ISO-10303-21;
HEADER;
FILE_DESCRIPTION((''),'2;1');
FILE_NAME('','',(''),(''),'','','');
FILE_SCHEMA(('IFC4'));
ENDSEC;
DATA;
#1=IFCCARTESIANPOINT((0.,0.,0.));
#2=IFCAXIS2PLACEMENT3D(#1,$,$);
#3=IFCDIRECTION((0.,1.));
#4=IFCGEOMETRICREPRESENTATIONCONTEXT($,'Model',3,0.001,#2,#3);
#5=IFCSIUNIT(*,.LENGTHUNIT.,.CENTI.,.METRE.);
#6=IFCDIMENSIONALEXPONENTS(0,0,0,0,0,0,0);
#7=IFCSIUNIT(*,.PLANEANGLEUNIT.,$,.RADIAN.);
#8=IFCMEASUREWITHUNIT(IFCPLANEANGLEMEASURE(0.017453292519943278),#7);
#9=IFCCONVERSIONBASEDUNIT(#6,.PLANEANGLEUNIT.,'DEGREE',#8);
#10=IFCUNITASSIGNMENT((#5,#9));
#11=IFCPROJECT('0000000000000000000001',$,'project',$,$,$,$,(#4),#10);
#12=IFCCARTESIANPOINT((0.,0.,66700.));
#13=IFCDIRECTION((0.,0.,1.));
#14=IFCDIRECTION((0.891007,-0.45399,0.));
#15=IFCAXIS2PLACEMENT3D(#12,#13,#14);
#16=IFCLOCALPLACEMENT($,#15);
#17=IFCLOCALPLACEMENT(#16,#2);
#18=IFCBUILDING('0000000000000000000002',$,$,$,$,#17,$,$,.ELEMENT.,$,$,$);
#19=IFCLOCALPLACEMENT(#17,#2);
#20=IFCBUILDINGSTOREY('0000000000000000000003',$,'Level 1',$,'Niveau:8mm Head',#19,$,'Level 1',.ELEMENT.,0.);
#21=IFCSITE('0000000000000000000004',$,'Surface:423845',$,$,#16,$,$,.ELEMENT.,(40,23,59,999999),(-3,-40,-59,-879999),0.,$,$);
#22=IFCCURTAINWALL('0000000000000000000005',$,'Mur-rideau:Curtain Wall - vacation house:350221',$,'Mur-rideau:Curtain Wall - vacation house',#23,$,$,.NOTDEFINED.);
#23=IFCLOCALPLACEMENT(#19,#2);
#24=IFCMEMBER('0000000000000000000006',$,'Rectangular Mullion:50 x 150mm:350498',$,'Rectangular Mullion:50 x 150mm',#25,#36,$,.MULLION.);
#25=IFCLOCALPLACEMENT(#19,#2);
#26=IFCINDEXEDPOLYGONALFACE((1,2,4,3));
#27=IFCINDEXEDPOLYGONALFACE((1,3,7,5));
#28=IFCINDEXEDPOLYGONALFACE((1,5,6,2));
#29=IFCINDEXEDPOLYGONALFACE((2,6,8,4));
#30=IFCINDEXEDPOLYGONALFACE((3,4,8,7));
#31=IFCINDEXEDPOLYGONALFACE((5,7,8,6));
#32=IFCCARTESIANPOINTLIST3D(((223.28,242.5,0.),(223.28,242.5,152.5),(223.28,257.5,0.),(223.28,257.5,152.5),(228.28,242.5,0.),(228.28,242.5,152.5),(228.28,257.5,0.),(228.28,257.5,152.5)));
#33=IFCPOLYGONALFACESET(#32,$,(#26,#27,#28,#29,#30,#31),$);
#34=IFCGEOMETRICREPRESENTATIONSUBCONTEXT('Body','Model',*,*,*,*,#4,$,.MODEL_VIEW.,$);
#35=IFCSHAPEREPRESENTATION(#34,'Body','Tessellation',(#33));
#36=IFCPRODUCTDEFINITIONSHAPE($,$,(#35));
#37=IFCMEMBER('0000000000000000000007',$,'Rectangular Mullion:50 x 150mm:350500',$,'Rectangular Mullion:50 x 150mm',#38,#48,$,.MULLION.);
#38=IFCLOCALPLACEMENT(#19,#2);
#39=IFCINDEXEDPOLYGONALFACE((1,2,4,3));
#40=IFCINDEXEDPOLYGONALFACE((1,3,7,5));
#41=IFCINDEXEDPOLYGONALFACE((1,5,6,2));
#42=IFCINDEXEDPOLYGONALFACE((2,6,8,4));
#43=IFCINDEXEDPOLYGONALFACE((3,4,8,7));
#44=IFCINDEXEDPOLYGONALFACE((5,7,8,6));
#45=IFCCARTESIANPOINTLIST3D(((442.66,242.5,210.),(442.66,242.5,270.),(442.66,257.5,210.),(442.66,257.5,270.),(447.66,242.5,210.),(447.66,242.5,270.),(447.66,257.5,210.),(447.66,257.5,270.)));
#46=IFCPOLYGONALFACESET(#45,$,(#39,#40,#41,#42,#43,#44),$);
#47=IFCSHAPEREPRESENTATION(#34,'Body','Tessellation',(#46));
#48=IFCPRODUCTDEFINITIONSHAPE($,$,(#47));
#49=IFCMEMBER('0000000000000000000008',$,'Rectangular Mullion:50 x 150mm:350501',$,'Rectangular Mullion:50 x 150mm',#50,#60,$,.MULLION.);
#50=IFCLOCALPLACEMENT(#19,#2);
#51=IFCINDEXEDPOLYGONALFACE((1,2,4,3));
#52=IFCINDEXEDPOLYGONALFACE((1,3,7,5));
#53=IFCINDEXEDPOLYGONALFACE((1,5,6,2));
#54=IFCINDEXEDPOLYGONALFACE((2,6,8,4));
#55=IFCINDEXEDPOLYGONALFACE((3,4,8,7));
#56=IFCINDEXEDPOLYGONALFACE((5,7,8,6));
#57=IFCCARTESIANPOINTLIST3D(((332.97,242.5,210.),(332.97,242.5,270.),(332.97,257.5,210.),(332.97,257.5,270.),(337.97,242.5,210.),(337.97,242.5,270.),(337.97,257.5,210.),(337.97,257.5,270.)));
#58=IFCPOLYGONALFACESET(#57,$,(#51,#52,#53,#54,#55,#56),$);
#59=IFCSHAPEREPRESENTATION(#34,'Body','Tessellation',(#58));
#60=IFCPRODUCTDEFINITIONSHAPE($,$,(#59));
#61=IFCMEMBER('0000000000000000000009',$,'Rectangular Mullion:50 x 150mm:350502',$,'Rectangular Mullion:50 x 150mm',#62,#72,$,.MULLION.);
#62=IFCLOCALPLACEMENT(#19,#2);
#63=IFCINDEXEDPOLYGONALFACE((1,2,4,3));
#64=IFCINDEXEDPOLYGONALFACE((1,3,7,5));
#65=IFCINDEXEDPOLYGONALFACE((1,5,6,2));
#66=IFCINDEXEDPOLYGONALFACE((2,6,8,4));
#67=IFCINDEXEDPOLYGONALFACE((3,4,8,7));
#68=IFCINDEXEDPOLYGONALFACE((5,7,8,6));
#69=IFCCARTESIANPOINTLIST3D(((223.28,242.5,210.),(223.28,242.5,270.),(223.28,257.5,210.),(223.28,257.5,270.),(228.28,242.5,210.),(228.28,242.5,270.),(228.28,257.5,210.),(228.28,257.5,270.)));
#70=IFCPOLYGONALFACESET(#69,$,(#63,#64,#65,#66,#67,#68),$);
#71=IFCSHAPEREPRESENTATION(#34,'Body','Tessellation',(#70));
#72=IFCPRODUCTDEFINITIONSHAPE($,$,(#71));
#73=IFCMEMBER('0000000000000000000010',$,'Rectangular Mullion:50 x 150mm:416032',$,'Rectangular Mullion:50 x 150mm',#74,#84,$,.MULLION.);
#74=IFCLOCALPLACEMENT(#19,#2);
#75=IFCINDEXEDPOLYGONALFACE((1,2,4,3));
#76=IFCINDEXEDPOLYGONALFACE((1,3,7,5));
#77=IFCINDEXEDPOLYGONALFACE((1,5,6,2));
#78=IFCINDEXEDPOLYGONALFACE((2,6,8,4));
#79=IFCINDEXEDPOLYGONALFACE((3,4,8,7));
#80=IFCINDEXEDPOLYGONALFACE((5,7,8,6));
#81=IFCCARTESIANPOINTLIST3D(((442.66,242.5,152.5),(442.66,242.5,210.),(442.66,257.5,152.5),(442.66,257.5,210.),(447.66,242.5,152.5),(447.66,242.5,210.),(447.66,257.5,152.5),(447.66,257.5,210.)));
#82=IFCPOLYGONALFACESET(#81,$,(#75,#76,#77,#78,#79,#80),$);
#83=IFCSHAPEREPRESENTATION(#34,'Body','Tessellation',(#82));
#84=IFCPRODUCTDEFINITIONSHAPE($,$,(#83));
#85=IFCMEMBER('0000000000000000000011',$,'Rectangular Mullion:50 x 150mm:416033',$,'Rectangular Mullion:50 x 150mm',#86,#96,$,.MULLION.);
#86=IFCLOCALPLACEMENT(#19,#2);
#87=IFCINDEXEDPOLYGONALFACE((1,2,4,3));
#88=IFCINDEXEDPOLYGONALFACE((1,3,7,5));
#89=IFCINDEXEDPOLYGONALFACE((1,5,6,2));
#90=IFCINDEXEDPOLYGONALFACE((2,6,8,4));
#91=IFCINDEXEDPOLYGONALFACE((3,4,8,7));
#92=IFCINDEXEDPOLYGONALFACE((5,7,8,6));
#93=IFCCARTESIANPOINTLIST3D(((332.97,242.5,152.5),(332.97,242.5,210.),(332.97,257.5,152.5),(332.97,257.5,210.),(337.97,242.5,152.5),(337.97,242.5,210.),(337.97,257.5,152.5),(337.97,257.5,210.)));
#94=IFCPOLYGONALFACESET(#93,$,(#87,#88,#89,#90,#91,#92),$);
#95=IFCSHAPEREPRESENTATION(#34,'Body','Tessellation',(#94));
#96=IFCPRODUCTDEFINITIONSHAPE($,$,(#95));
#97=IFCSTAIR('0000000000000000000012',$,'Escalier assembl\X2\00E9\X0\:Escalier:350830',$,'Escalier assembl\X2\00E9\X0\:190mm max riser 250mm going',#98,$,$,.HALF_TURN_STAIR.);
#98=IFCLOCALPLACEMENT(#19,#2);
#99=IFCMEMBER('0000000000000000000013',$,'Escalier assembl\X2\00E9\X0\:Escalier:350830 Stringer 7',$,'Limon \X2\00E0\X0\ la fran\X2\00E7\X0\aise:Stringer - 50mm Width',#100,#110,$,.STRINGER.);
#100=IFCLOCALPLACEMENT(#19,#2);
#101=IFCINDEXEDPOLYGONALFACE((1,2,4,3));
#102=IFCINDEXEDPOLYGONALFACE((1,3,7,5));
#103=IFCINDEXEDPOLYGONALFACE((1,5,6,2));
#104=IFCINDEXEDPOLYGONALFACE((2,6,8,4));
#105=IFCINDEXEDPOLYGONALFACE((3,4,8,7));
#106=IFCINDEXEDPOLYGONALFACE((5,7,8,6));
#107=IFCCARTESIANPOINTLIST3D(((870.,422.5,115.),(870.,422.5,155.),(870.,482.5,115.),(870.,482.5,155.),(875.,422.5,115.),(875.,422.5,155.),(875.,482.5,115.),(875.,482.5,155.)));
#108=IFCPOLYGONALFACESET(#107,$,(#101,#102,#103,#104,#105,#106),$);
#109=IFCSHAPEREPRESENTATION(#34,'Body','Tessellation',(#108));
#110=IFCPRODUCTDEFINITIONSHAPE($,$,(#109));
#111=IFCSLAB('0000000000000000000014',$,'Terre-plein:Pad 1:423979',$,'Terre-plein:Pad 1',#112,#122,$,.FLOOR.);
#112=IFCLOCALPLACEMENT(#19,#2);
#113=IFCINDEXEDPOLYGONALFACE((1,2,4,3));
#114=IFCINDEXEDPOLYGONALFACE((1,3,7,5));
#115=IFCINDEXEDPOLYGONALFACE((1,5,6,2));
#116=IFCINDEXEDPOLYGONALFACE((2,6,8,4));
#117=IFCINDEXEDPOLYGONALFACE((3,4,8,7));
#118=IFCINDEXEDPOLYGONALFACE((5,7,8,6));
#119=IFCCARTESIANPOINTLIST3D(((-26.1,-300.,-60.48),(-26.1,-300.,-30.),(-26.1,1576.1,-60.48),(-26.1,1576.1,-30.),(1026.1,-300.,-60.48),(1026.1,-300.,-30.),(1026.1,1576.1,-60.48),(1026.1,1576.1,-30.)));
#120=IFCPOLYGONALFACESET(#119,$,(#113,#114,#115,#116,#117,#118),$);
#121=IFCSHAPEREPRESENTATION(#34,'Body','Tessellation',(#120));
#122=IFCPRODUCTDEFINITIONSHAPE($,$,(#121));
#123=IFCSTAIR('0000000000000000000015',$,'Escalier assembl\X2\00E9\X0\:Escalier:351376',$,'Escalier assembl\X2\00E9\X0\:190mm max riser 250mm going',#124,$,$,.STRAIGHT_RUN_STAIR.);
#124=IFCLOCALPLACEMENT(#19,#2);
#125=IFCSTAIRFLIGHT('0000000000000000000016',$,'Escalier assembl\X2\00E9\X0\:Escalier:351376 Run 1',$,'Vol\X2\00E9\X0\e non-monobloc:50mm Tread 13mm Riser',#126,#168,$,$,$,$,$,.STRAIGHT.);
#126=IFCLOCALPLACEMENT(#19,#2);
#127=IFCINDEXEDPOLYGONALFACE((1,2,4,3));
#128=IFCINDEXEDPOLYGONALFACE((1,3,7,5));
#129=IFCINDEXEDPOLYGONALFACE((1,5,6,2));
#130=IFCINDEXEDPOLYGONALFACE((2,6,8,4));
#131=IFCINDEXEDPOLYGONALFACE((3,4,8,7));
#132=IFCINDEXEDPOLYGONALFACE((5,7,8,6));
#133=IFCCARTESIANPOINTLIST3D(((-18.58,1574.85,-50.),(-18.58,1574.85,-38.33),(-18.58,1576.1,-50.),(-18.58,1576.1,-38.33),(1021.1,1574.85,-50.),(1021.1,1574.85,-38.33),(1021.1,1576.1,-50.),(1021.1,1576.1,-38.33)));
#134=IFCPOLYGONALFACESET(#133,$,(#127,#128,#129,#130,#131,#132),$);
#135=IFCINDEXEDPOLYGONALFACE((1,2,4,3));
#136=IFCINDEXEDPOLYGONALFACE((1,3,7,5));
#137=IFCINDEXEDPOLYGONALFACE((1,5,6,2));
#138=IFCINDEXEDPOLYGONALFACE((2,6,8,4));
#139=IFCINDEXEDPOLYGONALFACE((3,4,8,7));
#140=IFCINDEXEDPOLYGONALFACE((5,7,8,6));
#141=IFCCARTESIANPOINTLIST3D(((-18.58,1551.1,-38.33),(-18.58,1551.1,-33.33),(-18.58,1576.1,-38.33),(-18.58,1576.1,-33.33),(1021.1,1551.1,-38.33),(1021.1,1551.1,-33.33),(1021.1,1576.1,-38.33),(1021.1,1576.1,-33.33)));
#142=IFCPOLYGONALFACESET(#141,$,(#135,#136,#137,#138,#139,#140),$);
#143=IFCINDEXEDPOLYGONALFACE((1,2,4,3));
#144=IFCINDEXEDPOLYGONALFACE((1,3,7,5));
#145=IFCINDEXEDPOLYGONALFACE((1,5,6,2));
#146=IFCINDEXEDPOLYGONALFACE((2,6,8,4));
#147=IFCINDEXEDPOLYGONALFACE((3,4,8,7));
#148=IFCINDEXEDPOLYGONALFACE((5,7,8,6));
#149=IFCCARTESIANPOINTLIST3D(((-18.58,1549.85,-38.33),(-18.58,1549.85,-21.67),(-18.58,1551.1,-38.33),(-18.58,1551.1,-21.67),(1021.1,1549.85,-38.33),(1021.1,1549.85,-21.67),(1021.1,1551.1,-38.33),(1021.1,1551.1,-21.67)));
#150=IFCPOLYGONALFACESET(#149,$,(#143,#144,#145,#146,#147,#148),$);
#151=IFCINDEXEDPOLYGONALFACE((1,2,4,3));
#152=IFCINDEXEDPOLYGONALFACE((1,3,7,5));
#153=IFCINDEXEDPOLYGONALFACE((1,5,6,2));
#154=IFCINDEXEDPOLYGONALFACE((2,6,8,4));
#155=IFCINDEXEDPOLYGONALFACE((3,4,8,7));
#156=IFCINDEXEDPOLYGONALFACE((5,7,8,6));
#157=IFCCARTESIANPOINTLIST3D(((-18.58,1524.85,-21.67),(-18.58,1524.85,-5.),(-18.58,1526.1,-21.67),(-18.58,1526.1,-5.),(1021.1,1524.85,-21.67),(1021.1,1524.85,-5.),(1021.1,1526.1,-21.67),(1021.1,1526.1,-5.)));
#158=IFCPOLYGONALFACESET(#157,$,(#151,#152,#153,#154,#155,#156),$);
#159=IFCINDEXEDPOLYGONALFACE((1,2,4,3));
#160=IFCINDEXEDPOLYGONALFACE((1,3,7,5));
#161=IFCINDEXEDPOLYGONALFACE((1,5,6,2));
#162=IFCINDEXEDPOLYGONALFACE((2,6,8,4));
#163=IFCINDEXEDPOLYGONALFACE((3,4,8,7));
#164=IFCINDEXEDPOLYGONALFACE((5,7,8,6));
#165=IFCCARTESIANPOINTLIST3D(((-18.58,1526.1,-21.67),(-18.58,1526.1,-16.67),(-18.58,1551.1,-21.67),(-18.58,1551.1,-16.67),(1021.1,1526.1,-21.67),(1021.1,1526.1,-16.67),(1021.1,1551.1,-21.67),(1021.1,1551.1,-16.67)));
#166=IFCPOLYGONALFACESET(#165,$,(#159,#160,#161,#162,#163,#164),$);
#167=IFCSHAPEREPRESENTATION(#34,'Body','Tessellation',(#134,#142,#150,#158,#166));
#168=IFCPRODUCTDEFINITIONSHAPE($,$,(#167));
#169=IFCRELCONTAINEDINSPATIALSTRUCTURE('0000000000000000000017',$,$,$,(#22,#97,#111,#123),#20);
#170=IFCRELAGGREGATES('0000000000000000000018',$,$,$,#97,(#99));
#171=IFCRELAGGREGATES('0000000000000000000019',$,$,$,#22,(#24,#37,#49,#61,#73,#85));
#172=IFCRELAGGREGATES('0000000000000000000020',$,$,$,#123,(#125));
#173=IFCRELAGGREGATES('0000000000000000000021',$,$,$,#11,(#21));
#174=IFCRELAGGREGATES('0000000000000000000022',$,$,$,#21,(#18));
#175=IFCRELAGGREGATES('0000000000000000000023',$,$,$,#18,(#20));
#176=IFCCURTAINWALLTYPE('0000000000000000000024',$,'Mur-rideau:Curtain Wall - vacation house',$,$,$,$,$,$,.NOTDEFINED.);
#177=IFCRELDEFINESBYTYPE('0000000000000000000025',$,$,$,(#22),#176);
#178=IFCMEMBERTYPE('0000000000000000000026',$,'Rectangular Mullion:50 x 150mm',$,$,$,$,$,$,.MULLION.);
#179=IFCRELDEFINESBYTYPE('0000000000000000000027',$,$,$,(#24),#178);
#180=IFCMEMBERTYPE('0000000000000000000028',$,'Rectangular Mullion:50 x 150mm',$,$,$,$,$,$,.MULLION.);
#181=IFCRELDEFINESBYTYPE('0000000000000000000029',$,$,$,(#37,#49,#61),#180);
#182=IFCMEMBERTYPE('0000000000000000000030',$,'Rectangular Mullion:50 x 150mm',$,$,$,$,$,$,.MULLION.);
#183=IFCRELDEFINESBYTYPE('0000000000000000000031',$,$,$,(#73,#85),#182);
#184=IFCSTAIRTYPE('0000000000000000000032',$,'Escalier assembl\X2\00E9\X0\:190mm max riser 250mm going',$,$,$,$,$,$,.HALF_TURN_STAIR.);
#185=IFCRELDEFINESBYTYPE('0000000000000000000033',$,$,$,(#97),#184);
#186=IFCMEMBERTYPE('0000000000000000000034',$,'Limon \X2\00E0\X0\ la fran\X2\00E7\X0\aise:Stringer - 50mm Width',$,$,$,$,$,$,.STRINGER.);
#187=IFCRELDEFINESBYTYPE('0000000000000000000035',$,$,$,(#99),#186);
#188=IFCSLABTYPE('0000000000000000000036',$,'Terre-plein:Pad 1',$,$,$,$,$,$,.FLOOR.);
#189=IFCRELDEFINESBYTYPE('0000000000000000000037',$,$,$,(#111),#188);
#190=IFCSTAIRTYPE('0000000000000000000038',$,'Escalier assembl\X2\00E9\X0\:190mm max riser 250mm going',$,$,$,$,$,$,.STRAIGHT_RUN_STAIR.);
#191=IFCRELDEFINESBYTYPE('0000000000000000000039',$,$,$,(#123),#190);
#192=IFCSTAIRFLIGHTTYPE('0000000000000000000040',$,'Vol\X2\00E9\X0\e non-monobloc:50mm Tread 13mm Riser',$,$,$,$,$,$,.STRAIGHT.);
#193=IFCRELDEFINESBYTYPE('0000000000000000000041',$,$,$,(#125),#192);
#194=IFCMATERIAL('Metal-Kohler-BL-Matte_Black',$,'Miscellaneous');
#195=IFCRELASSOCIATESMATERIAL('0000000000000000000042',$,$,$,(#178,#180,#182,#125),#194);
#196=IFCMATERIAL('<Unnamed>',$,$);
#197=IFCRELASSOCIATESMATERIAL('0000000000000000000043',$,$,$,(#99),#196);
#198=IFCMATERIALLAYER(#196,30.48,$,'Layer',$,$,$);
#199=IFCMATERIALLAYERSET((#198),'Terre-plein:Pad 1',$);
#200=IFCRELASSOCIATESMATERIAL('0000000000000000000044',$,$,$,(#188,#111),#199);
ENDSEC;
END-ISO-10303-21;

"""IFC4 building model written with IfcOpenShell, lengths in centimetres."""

from ifc_helpers import new_model, entity, si_unit, converted_unit, direction, frame, frame_2d, origin, origin_2d_with_axis, place, context, subcontext, project, spatial, rectangle, extrude, source, transform, mapped, material, layer, layer_set, layer_usage, material_profile, profile_set, type_object, type_shapes, element, aggregate, save


model = new_model("IFC4")

# Units and contexts
model_context = context("Model", 3, precision=0.001, world=origin(), true_north=direction((0.0, 1.0)))
body_context = subcontext(model_context, "Body", "Model", "MODEL_VIEW")
ifc_project = project(units=[si_unit("LENGTHUNIT", "METRE", prefix="CENTI"), converted_unit("PLANEANGLEUNIT", "DEGREE", entity("IfcPlaneAngleMeasure", 0.017453292519943278), si_unit("PLANEANGLEUNIT", "RADIAN"), dimensions=[0, 0, 0, 0, 0, 0, 0])], contexts=[model_context])

# Site, building, storey
site_placement = place(None, frame((0.0, 0.0, 66700.0), z_axis=(0.0, 0.0, 1.0), x_axis=(0.891007, -0.45399, 0.0)))
site = spatial("IfcSite", under=ifc_project, at=site_placement, Name="Surface:423845", CompositionType="ELEMENT", RefLatitude=(40, 23, 59, 999999), RefLongitude=(-3, -40, -59, -879999), RefElevation=0.0)
building_placement = place(site_placement, origin())
building = spatial("IfcBuilding", under=site, at=building_placement, CompositionType="ELEMENT")
storey_placement = place(building_placement, origin())
storey = spatial("IfcBuildingStorey", under=building, at=storey_placement, Name="Level 1", ObjectType="Niveau:8mm Head", LongName="Level 1", CompositionType="ELEMENT", Elevation=0.0)

# Curtain wall, members
curtain_wall_type = type_object("IfcCurtainWallType", Name="Mur-rideau:Curtain Wall - vacation house", PredefinedType="NOTDEFINED")
curtain_wall_placement = place(storey_placement, origin())
curtain_wall = element("IfcCurtainWall", 1, at=curtain_wall_placement, inside=storey, type_object=curtain_wall_type, Name="Mur-rideau:Curtain Wall - vacation house:350221", ObjectType="Mur-rideau:Curtain Wall - vacation house", PredefinedType="NOTDEFINED")
ifc_material_1 = material(Name="Metal-Kohler-BL-Matte_Black", Category="Miscellaneous")
ifc_material_profile = material_profile(ifc_material_1, rectangle(XDim=5.0, YDim=15.0, at=origin_2d_with_axis()), Name="50 x 150mm")
ifc_profile_set = profile_set([ifc_material_profile], Name="50 x 150mm")
member_type_1 = type_object("IfcMemberType", Name="Rectangular Mullion:50 x 150mm", PredefinedType="MULLION", material=ifc_profile_set)
shared_shape_1 = source(origin(), body_context, "Body", "SweptSolid", [
    extrude(rectangle(XDim=5.0, YDim=15.0, at=origin_2d_with_axis()), frame((0.0, 0.0, -152.5), z_axis=(0.0, 0.0, 1.0), x_axis=(-1.0, 0.0, 0.0)), (0.0, 0.0, 1.0), 152.5),
])
type_shapes(member_type_1, [shared_shape_1])
member_1_placement = place(curtain_wall_placement, frame((225.78, 250.0, 0.0), z_axis=(0.0, 0.0, -1.0), x_axis=(-1.0, 0.0, 0.0)))
member_1 = element("IfcMember", 2, at=member_1_placement, type_object=member_type_1, Name="Rectangular Mullion:50 x 150mm:350498", ObjectType="Rectangular Mullion:50 x 150mm", PredefinedType="MULLION", context=body_context, shape_type="MappedRepresentation", body=[
    mapped(shared_shape_1, transform((0.0, 0.0, 0.0), scale=1.0)),
])
member_type_2 = type_object("IfcMemberType", Name="Rectangular Mullion:50 x 150mm", PredefinedType="MULLION", material=ifc_profile_set)
shared_shape_2 = source(origin(), body_context, "Body", "SweptSolid", [
    extrude(rectangle(XDim=5.0, YDim=15.0, at=origin_2d_with_axis()), frame((0.0, 0.0, -60.0), z_axis=(0.0, 0.0, 1.0), x_axis=(-1.0, 0.0, 0.0)), (0.0, 0.0, 1.0), 60.0),
])
type_shapes(member_type_2, [shared_shape_2])
member_2_placement = place(curtain_wall_placement, frame((445.16, 250.0, 210.0), z_axis=(0.0, 0.0, -1.0), x_axis=(-1.0, 0.0, 0.0)))
member_2 = element("IfcMember", 3, at=member_2_placement, type_object=member_type_2, Name="Rectangular Mullion:50 x 150mm:350500", ObjectType="Rectangular Mullion:50 x 150mm", PredefinedType="MULLION", context=body_context, shape_type="MappedRepresentation", body=[
    mapped(shared_shape_2, transform((0.0, 0.0, 0.0), scale=1.0)),
])
member_3_placement = place(curtain_wall_placement, frame((335.47, 250.0, 210.0), z_axis=(0.0, 0.0, -1.0), x_axis=(-1.0, 0.0, 0.0)))
member_3 = element("IfcMember", 4, at=member_3_placement, type_object=member_type_2, Name="Rectangular Mullion:50 x 150mm:350501", ObjectType="Rectangular Mullion:50 x 150mm", PredefinedType="MULLION", context=body_context, shape_type="MappedRepresentation", body=[
    mapped(shared_shape_2, transform((0.0, 0.0, 0.0), scale=1.0)),
])
member_4_placement = place(curtain_wall_placement, frame((225.78, 250.0, 210.0), z_axis=(0.0, 0.0, -1.0), x_axis=(-1.0, 0.0, 0.0)))
member_4 = element("IfcMember", 5, at=member_4_placement, type_object=member_type_2, Name="Rectangular Mullion:50 x 150mm:350502", ObjectType="Rectangular Mullion:50 x 150mm", PredefinedType="MULLION", context=body_context, shape_type="MappedRepresentation", body=[
    mapped(shared_shape_2, transform((0.0, 0.0, 0.0), scale=1.0)),
])
member_type_3 = type_object("IfcMemberType", Name="Rectangular Mullion:50 x 150mm", PredefinedType="MULLION", material=ifc_profile_set)
shared_shape_3 = source(origin(), body_context, "Body", "SweptSolid", [
    extrude(rectangle(XDim=5.0, YDim=15.0, at=origin_2d_with_axis()), frame((0.0, 0.0, -57.5), z_axis=(0.0, 0.0, 1.0), x_axis=(-1.0, 0.0, 0.0)), (0.0, 0.0, 1.0), 57.5),
])
type_shapes(member_type_3, [shared_shape_3])
member_5_placement = place(curtain_wall_placement, frame((445.16, 250.0, 152.5), z_axis=(0.0, 0.0, -1.0), x_axis=(-1.0, 0.0, 0.0)))
member_5 = element("IfcMember", 6, at=member_5_placement, type_object=member_type_3, Name="Rectangular Mullion:50 x 150mm:416032", ObjectType="Rectangular Mullion:50 x 150mm", PredefinedType="MULLION", context=body_context, shape_type="MappedRepresentation", body=[
    mapped(shared_shape_3, transform((0.0, 0.0, 0.0), scale=1.0)),
])
member_6_placement = place(curtain_wall_placement, frame((335.47, 250.0, 152.5), z_axis=(0.0, 0.0, -1.0), x_axis=(-1.0, 0.0, 0.0)))
member_6 = element("IfcMember", 7, at=member_6_placement, type_object=member_type_3, Name="Rectangular Mullion:50 x 150mm:416033", ObjectType="Rectangular Mullion:50 x 150mm", PredefinedType="MULLION", context=body_context, shape_type="MappedRepresentation", body=[
    mapped(shared_shape_3, transform((0.0, 0.0, 0.0), scale=1.0)),
])

# Stair, member
stair_type_1 = type_object("IfcStairType", Name="Escalier assemblé:190mm max riser 250mm going", PredefinedType="HALF_TURN_STAIR")
stair_1_placement = place(storey_placement, origin())
stair_1 = element("IfcStair", 8, at=stair_1_placement, inside=storey, type_object=stair_type_1, Name="Escalier assemblé:Escalier:350830", ObjectType="Escalier assemblé:190mm max riser 250mm going", PredefinedType="HALF_TURN_STAIR")
ifc_material_2 = material(Name="<Unnamed>")
member_type_4 = type_object("IfcMemberType", Name="Limon à la française:Stringer - 50mm Width", PredefinedType="STRINGER")
member_7_placement = place(stair_1_placement, origin())
member_7 = element("IfcMember", 9, at=member_7_placement, type_object=member_type_4, material=ifc_material_2, Name="Escalier assemblé:Escalier:350830 Stringer 7", ObjectType="Limon à la française:Stringer - 50mm Width", PredefinedType="STRINGER", context=body_context, shape_type="SweptSolid", body=[
    extrude(rectangle(XDim=60.0, YDim=5.0, at=frame_2d((0.0, 0.0), x_axis=(1.0, 0.0))), frame((872.5, 452.5, 115.0), z_axis=(0.0, 0.0, 1.0), x_axis=(0.0, -1.0, 0.0)), (0.0, 0.0, 1.0), 40.0),
])
aggregate(stair_1, [member_7])

aggregate(curtain_wall, [member_1, member_2, member_3, member_4, member_5, member_6])

# Slab
ifc_layer = layer(ifc_material_2, 30.48, Name="Layer")
ifc_layer_set = layer_set([ifc_layer], Name="Terre-plein:Pad 1")
ifc_layer_usage = layer_usage(ifc_layer_set, "AXIS3", "NEGATIVE", 0.0)
slab_type = type_object("IfcSlabType", Name="Terre-plein:Pad 1", PredefinedType="FLOOR", material=ifc_layer_set)
slab_placement = place(storey_placement, origin())
element("IfcSlab", 10, at=slab_placement, inside=storey, type_object=slab_type, material=ifc_layer_usage, Name="Terre-plein:Pad 1:423979", ObjectType="Terre-plein:Pad 1", PredefinedType="FLOOR", context=body_context, shape_type="SweptSolid", body=[
    extrude(rectangle(XDim=1052.2, YDim=1876.1, at=frame_2d((0.0, 0.0), x_axis=(1.0, 0.0))), frame((500.0, 638.05, -60.48)), (0.0, 0.0, 1.0), 30.48),
])

# Stair, stair flight
stair_type_2 = type_object("IfcStairType", Name="Escalier assemblé:190mm max riser 250mm going", PredefinedType="STRAIGHT_RUN_STAIR")
stair_2_placement = place(storey_placement, origin())
stair_2 = element("IfcStair", 11, at=stair_2_placement, inside=storey, type_object=stair_type_2, Name="Escalier assemblé:Escalier:351376", ObjectType="Escalier assemblé:190mm max riser 250mm going", PredefinedType="STRAIGHT_RUN_STAIR")
stair_flight_type = type_object("IfcStairFlightType", Name="Volée non-monobloc:50mm Tread 13mm Riser", PredefinedType="STRAIGHT")
stair_flight_placement = place(stair_2_placement, origin())
stair_flight = element("IfcStairFlight", 12, at=stair_flight_placement, type_object=stair_flight_type, material=ifc_material_1, Name="Escalier assemblé:Escalier:351376 Run 1", ObjectType="Volée non-monobloc:50mm Tread 13mm Riser", PredefinedType="STRAIGHT", context=body_context, shape_type="SweptSolid", body=[
    extrude(rectangle(XDim=1039.68, YDim=1.25, at=frame_2d((0.0, 0.0), x_axis=(1.0, 0.0))), frame((501.26, 1575.47, -50.0)), (0.0, 0.0, 1.0), 11.67),
    extrude(rectangle(XDim=25.0, YDim=1039.68, at=frame_2d((0.0, 0.0), x_axis=(1.0, 0.0))), frame((501.26, 1563.6, -38.33), z_axis=(0.0, 0.0, 1.0), x_axis=(0.0, 1.0, 0.0)), (0.0, 0.0, 1.0), 5.0),
    extrude(rectangle(XDim=1039.68, YDim=1.25, at=frame_2d((0.0, 0.0), x_axis=(1.0, 0.0))), frame((501.26, 1550.47, -38.33)), (0.0, 0.0, 1.0), 16.67),
    extrude(rectangle(XDim=1039.68, YDim=1.25, at=frame_2d((0.0, 0.0), x_axis=(1.0, 0.0))), frame((501.26, 1525.47, -21.67)), (0.0, 0.0, 1.0), 16.67),
    extrude(rectangle(XDim=25.0, YDim=1039.68, at=frame_2d((0.0, 0.0), x_axis=(1.0, 0.0))), frame((501.26, 1538.6, -21.67), z_axis=(0.0, 0.0, 1.0), x_axis=(0.0, 1.0, 0.0)), (0.0, 0.0, 1.0), 5.0),
])
aggregate(stair_2, [stair_flight])

save(model, "model.ifc")
